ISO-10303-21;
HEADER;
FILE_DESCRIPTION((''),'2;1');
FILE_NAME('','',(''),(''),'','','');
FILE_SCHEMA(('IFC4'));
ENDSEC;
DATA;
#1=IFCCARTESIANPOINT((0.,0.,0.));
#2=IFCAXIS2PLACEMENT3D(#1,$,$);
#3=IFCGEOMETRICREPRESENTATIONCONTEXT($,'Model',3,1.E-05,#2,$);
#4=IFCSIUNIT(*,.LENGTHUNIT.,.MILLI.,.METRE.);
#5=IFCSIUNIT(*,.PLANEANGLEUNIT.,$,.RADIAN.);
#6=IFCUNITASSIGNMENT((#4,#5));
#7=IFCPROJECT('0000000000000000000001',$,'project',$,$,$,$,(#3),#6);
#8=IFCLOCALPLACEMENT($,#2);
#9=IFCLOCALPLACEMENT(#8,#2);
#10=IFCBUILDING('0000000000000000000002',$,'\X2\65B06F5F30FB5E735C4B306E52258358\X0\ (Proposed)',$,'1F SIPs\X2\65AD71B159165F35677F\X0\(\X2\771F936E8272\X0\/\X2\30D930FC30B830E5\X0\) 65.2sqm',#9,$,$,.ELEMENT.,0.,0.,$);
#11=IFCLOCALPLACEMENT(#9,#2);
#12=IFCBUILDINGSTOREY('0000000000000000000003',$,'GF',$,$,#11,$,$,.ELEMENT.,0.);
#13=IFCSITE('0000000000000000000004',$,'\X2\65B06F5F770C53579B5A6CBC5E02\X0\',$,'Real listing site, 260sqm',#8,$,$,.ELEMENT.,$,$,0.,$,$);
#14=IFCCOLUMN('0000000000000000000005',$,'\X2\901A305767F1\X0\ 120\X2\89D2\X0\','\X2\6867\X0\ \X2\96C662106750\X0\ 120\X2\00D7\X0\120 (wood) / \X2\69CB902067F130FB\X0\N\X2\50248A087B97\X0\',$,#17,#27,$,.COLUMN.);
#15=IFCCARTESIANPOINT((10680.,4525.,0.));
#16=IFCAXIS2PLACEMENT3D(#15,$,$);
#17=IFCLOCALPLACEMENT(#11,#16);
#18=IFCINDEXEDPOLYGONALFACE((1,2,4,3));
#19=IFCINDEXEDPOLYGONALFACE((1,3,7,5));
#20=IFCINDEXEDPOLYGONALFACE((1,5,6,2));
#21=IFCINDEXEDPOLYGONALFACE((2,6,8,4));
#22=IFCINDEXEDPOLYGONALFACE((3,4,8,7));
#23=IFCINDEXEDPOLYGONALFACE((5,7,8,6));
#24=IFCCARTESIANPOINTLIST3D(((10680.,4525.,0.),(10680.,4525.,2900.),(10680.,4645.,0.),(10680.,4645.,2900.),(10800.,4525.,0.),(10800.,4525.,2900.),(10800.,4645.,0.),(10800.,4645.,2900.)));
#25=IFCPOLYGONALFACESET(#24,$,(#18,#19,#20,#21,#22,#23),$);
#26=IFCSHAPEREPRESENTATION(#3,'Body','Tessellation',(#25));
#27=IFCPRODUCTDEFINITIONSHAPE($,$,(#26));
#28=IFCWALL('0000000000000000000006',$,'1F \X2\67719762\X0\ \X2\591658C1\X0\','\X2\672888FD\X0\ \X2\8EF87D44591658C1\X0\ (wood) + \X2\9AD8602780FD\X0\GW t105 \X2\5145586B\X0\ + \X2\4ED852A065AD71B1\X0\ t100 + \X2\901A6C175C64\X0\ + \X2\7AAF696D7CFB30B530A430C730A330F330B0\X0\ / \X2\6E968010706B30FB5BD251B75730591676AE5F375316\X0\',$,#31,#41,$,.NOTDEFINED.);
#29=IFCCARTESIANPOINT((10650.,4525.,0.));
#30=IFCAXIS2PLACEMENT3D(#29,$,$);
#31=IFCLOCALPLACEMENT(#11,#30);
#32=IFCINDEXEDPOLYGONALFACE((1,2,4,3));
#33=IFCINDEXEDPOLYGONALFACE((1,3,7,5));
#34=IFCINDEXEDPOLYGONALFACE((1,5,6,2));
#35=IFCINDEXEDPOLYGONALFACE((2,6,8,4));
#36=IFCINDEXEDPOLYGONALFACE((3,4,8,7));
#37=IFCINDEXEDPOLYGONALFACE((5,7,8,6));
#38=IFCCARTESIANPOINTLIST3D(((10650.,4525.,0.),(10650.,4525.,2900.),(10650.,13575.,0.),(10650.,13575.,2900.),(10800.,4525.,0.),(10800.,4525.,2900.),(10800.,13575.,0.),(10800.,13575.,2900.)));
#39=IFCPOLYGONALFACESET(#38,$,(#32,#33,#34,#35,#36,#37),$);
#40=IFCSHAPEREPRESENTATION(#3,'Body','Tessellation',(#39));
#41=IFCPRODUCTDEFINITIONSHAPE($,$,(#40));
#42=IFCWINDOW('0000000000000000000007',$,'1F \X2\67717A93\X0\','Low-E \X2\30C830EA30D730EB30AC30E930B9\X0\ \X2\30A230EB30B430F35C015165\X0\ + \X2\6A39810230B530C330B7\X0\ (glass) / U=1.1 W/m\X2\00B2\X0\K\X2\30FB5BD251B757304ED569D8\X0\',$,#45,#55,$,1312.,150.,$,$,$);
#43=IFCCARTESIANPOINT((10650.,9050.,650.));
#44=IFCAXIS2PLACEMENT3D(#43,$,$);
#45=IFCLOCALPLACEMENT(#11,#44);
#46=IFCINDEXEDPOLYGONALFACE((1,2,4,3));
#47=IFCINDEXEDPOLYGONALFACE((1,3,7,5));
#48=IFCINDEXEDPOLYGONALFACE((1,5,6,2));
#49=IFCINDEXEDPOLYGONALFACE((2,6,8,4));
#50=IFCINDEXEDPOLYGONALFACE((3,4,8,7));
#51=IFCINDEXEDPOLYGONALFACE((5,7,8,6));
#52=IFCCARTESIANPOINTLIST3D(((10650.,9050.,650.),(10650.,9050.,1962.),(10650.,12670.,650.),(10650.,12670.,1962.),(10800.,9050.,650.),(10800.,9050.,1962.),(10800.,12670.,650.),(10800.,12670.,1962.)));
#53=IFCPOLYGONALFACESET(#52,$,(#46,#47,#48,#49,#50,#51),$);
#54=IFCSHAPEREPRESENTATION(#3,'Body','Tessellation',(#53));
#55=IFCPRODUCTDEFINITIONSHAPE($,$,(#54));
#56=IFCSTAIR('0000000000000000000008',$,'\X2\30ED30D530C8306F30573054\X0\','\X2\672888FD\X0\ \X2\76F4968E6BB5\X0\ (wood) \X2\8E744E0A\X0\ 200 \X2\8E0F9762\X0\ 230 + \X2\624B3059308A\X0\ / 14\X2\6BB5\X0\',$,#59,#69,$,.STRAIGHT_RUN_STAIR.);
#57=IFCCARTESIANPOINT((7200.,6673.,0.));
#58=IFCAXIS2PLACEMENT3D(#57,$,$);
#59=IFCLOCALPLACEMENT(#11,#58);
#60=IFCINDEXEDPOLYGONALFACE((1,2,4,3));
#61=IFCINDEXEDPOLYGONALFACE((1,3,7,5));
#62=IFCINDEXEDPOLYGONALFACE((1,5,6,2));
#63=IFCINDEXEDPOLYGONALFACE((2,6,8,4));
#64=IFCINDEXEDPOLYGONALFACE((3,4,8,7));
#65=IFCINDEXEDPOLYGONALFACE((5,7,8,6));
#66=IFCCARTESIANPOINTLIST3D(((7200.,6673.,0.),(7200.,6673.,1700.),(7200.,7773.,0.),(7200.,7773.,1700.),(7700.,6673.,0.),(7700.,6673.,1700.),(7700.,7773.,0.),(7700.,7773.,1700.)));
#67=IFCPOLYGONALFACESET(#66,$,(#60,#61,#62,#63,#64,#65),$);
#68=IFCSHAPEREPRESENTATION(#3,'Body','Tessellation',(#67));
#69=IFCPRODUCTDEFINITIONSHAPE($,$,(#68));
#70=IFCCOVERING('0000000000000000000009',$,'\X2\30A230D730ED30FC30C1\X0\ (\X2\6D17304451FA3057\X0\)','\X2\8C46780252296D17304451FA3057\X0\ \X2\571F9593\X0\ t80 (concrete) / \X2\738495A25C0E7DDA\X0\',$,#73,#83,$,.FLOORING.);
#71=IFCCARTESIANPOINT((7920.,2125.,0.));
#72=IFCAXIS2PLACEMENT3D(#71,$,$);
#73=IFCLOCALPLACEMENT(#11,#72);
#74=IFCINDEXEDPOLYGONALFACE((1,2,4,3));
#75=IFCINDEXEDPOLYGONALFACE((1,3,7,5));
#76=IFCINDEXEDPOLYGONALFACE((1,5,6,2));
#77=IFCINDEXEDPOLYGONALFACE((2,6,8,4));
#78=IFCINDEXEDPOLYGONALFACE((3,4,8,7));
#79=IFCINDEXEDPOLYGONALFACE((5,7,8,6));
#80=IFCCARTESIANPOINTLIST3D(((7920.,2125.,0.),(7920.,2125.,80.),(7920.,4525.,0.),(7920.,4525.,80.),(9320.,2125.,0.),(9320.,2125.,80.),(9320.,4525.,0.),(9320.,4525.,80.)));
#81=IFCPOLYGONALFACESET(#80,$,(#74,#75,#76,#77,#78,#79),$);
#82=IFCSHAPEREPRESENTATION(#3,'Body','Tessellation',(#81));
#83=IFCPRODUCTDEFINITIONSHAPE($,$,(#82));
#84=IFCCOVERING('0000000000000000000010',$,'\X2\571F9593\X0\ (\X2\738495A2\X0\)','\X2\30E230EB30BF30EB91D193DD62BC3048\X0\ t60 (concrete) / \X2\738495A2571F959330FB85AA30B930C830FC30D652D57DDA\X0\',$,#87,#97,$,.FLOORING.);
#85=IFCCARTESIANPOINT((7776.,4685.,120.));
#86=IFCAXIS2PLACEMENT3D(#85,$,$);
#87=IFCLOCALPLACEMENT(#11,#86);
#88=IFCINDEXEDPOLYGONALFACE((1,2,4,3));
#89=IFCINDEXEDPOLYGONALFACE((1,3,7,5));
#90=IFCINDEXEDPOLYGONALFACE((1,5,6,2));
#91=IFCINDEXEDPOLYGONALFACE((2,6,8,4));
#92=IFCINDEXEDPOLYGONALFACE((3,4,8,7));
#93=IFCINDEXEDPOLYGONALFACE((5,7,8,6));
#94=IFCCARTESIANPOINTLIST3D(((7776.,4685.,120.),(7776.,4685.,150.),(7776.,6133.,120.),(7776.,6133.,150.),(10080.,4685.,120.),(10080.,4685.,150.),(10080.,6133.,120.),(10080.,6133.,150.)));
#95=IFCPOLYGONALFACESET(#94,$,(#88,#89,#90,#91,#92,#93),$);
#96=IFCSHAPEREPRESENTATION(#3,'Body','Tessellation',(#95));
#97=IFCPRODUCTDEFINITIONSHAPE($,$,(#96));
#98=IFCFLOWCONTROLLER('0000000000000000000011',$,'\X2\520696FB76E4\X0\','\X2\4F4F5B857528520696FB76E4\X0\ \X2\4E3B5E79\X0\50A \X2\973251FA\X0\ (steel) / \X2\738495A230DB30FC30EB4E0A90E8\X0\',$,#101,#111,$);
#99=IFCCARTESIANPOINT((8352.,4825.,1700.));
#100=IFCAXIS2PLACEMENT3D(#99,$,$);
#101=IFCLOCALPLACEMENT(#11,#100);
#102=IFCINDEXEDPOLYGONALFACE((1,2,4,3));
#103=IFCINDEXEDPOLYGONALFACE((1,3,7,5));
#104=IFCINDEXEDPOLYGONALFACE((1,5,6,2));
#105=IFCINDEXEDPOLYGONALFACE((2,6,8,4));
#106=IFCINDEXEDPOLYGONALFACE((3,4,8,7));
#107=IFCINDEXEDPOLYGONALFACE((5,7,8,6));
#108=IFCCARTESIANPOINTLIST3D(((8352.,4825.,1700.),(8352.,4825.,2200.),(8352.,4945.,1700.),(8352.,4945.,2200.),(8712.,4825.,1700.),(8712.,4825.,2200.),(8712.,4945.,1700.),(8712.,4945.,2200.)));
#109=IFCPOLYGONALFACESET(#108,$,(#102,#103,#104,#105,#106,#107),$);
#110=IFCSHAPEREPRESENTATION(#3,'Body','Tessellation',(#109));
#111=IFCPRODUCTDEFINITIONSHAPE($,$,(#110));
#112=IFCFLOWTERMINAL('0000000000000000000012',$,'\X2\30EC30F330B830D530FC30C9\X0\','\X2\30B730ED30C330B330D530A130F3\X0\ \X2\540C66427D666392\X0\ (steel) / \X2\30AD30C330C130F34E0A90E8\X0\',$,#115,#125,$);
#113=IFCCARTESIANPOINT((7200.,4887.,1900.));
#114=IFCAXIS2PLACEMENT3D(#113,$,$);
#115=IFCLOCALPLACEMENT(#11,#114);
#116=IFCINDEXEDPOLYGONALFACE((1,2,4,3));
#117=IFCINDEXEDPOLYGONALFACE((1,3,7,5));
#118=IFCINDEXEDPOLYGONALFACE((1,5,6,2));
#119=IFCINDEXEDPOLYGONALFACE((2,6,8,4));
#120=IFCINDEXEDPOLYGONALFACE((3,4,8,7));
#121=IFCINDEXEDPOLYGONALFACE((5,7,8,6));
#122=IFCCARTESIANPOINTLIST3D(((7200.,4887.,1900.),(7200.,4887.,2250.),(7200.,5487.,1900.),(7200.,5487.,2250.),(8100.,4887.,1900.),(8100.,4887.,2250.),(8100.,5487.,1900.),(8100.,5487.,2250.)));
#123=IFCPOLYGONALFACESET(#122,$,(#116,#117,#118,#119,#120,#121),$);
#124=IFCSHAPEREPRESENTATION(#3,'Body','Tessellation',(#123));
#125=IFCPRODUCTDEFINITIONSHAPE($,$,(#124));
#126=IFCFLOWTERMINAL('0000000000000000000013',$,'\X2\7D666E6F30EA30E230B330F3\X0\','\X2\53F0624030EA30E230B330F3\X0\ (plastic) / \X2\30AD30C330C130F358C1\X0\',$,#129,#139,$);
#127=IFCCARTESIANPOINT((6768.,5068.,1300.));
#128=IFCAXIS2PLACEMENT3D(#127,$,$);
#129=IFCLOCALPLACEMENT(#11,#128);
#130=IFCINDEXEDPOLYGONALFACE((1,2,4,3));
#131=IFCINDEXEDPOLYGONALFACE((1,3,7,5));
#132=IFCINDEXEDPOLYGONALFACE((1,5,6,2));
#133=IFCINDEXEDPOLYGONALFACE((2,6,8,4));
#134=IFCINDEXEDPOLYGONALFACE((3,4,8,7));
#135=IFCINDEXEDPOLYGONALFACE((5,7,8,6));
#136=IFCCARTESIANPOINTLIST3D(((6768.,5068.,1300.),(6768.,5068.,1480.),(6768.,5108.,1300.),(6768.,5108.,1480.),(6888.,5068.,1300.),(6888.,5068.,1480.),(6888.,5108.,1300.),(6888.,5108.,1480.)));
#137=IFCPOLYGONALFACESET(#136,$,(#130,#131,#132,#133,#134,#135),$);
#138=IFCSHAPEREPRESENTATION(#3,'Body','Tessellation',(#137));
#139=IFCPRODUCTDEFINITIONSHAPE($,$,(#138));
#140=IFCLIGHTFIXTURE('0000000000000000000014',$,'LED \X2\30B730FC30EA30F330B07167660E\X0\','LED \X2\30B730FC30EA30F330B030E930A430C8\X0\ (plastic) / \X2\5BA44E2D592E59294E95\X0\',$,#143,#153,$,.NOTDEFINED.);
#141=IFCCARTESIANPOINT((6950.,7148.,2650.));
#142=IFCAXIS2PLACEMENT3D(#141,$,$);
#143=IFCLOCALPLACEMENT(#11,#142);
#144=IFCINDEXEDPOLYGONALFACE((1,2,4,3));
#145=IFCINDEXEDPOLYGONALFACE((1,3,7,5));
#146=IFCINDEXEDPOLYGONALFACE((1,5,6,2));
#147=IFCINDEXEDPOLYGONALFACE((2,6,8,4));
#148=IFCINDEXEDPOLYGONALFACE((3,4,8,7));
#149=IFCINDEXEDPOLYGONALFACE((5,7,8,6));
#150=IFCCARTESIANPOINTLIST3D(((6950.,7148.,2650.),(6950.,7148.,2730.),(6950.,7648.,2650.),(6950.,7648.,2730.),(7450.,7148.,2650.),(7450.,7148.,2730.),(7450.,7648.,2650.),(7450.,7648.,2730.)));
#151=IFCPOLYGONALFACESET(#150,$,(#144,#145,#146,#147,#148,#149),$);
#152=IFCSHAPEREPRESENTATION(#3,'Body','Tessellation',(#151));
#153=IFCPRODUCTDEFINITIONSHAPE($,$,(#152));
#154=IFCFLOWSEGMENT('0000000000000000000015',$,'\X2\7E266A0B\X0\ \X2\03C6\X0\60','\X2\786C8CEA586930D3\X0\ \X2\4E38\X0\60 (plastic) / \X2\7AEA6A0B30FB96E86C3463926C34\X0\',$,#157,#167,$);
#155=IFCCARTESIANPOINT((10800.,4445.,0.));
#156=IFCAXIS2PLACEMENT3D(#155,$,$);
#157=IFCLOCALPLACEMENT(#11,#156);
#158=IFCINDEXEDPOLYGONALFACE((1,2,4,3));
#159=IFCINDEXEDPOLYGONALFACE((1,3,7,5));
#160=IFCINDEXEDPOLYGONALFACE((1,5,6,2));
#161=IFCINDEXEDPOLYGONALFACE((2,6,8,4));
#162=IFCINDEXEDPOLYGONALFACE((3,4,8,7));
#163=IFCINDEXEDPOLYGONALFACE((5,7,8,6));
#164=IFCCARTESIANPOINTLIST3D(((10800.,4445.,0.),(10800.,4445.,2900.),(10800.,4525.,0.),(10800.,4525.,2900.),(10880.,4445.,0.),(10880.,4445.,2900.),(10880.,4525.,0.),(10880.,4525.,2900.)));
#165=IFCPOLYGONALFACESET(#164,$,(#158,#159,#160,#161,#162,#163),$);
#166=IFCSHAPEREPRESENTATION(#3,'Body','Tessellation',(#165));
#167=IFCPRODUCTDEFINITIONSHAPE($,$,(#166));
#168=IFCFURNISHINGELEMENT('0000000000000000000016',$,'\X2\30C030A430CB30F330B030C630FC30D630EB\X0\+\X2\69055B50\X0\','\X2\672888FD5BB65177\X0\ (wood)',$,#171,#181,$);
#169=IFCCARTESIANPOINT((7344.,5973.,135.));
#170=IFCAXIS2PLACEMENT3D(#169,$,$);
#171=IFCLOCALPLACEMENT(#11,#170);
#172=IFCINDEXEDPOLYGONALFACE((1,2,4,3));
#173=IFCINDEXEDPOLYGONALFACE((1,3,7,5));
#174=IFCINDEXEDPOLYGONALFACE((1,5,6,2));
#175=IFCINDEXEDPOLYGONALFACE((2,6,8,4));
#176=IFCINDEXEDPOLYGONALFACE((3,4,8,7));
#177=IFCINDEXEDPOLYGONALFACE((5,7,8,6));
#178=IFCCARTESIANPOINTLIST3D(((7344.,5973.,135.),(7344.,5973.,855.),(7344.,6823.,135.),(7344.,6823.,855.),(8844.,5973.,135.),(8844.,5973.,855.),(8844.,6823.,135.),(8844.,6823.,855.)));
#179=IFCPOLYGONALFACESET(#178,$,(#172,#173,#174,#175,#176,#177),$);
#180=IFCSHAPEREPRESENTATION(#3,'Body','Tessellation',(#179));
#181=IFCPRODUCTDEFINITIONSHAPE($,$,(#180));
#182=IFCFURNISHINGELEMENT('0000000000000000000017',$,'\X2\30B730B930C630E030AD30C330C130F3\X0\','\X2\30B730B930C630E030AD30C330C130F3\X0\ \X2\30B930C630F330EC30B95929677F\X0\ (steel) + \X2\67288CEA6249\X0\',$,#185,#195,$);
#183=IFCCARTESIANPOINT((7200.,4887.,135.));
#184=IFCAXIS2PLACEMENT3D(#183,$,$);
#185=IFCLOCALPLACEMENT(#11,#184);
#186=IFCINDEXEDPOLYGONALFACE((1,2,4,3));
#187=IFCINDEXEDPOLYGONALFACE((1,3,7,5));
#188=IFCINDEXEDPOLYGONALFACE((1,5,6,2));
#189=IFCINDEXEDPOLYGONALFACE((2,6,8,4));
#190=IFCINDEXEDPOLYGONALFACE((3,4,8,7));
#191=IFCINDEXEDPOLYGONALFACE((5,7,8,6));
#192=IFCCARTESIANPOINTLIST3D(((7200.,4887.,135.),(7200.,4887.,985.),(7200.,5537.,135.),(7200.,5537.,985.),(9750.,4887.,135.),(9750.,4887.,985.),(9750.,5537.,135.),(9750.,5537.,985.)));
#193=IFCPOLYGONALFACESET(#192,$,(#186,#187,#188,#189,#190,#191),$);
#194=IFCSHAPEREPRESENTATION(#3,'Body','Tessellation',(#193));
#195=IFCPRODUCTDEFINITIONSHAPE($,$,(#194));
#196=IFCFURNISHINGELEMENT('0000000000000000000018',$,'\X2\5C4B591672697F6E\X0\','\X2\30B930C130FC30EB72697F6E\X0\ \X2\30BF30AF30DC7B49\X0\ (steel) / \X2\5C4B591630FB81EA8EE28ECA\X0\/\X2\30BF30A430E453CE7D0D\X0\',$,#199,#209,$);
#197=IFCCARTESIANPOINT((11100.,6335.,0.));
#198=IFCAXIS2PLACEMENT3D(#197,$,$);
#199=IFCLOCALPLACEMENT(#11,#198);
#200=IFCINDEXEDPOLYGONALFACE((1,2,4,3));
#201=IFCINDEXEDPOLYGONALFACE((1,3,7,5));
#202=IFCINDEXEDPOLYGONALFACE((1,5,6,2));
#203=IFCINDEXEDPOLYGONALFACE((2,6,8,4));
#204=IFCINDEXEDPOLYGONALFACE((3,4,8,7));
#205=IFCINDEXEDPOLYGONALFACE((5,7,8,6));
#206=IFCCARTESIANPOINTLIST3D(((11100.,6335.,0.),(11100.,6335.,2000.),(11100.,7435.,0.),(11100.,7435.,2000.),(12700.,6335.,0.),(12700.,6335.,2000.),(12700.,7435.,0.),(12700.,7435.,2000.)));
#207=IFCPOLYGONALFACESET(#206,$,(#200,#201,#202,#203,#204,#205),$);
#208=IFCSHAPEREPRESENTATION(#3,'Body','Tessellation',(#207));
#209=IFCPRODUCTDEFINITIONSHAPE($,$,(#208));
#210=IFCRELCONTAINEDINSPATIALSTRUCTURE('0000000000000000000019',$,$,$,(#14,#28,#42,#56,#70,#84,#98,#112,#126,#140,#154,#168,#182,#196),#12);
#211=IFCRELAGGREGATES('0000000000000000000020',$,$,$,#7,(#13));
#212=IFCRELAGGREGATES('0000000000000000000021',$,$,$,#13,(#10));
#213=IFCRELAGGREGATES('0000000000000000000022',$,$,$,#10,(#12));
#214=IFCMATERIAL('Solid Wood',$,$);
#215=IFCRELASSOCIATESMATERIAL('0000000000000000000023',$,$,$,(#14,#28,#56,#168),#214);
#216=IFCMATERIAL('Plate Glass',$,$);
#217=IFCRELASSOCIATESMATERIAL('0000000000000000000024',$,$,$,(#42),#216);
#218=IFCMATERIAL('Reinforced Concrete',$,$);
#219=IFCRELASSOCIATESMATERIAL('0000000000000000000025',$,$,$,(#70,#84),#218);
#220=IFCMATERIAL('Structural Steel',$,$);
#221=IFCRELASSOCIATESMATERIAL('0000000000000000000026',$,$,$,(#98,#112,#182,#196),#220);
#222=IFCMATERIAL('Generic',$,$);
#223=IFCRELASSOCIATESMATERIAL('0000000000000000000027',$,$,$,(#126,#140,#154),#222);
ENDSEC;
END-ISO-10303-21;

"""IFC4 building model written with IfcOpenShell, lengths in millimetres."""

from ifc_helpers import new_model, si_unit, frame, frame_2d, origin, place, context, project, spatial, rectangle, extrude, material, element, fill, save


model = new_model("IFC4")

# Units and contexts
model_context = context("Model", 3, precision=1e-05, world=origin())
ifc_project = project(units=[si_unit("LENGTHUNIT", "METRE", prefix="MILLI"), si_unit("PLANEANGLEUNIT", "RADIAN")], contexts=[model_context])

# Site, building, storey
site_placement = place(None, origin())
site = spatial("IfcSite", under=ifc_project, at=site_placement, Name="新潟県南魚沼市", ObjectType="Real listing site, 260sqm", CompositionType="ELEMENT", RefElevation=0.0)
building_placement = place(site_placement, origin())
building = spatial("IfcBuilding", under=site, at=building_placement, Name="新潟・平屋の別荘 (Proposed)", ObjectType="1F SIPs断熱外張板(真鍮色/ベージュ) 65.2sqm", CompositionType="ELEMENT", ElevationOfRefHeight=0.0, ElevationOfTerrain=0.0)
storey_placement = place(building_placement, origin())
storey = spatial("IfcBuildingStorey", under=building, at=storey_placement, Name="GF", CompositionType="ELEMENT", Elevation=0.0)

# Column
ifc_material_1 = material(Name="Solid Wood")
column_1_placement = place(storey_placement, frame((10680.0, 4525.0, 0.0)))
element("IfcColumn", 1, at=column_1_placement, inside=storey, material=ifc_material_1, Name="通し柱 120角", Description="桧 集成材 120×120 (wood) / 構造柱・N値計算", PredefinedType="COLUMN", context=model_context, shape_type="SweptSolid", body=[
    extrude(rectangle(XDim=120.0, YDim=120.0, at=frame_2d((60.0, 60.0))), frame((10680.0, 4525.0, 0.0)), (0.0, 0.0, 1.0), 2900.0),
])

# Wall, opening, window
wall_1_placement = place(storey_placement, frame((10650.0, 4525.0, 0.0)))
wall_1 = element("IfcWall", 2, at=wall_1_placement, inside=storey, material=ifc_material_1, Name="1F 東面 外壁", Description="木製 軸組外壁 (wood) + 高性能GW t105 充填 + 付加断熱 t100 + 通気層 + 窯業系サイディング / 準耐火・寒冷地外皮強化", PredefinedType="NOTDEFINED", context=model_context, shape_type="SweptSolid", body=[
    extrude(rectangle(XDim=150.0, YDim=9050.0, at=frame_2d((75.0, 4525.0))), frame((10650.0, 4525.0, 0.0)), (0.0, 0.0, 1.0), 2900.0),
])
opening_placement = place(storey_placement, frame((10650.0, 9050.0, 650.0)))
opening = element("IfcOpeningElement", 3, at=opening_placement, cuts=wall_1, PredefinedType="NOTDEFINED", context=model_context, shape_type="SweptSolid", body=[
    extrude(rectangle(XDim=150.0, YDim=3620.0, at=frame_2d((75.0, 1810.0))), frame((10650.0, 9050.0, 650.0)), (0.0, 0.0, 1.0), 1312.0),
])
ifc_material_2 = material(Name="Plate Glass")
window_placement = place(storey_placement, frame((10650.0, 9050.0, 650.0)))
window = element("IfcWindow", 4, at=window_placement, inside=storey, material=ifc_material_2, Name="1F 東窓", Description="Low-E トリプルガラス アルゴン封入 + 樹脂サッシ (glass) / U=1.1 W/m²K・寒冷地仕様", OverallHeight=1312.0, OverallWidth=150.0, context=model_context, shape_type="SweptSolid", body=[
    extrude(rectangle(XDim=150.0, YDim=3620.0, at=frame_2d((75.0, 1810.0))), frame((10650.0, 9050.0, 650.0)), (0.0, 0.0, 1.0), 1312.0),
])
fill(opening, window)

# Stair
stair_placement = place(storey_placement, frame((7200.0, 6673.0, 0.0)))
element("IfcStair", 5, at=stair_placement, inside=storey, material=ifc_material_1, Name="ロフトはしご", Description="木製 直階段 (wood) 蹴上 200 踏面 230 + 手すり / 14段", PredefinedType="STRAIGHT_RUN_STAIR", context=model_context, shape_type="SweptSolid", body=[
    extrude(rectangle(XDim=500.0, YDim=1100.0, at=frame_2d((250.0, 550.0))), frame((7200.0, 6673.0, 0.0)), (0.0, 0.0, 1.0), 1700.0),
])

# Coverings
ifc_material_3 = material(Name="Reinforced Concrete")
covering_1_placement = place(storey_placement, frame((7920.0, 2125.0, 0.0)))
element("IfcCovering", 6, at=covering_1_placement, inside=storey, material=ifc_material_3, Name="アプローチ (洗い出し)", Description="豆砂利洗い出し 土間 t80 (concrete) / 玄関導線", PredefinedType="FLOORING", context=model_context, shape_type="SweptSolid", body=[
    extrude(rectangle(XDim=1400.0, YDim=2400.0, at=frame_2d((700.0, 1200.0))), frame((7920.0, 2125.0, 0.0)), (0.0, 0.0, 1.0), 80.0),
])
covering_2_placement = place(storey_placement, frame((7776.0, 4685.0, 120.0)))
element("IfcCovering", 7, at=covering_2_placement, inside=storey, material=ifc_material_3, Name="土間 (玄関)", Description="モルタル金鏝押え t60 (concrete) / 玄関土間・薪ストーブ動線", PredefinedType="FLOORING", context=model_context, shape_type="SweptSolid", body=[
    extrude(rectangle(XDim=2304.0, YDim=1448.0, at=frame_2d((1152.0, 724.0))), frame((7776.0, 4685.0, 120.0)), (0.0, 0.0, 1.0), 30.0),
])

# Flow controller
ifc_material_4 = material(Name="Structural Steel")
flow_controller_placement = place(storey_placement, frame((8352.0, 4825.0, 1700.0)))
element("IfcFlowController", 8, at=flow_controller_placement, inside=storey, material=ifc_material_4, Name="分電盤", Description="住宅用分電盤 主幹50A 露出 (steel) / 玄関ホール上部", context=model_context, shape_type="SweptSolid", body=[
    extrude(rectangle(XDim=360.0, YDim=120.0, at=frame_2d((180.0, 60.0))), frame((8352.0, 4825.0, 1700.0)), (0.0, 0.0, 1.0), 500.0),
])

# Flow terminals
flow_terminal_1_placement = place(storey_placement, frame((7200.0, 4887.0, 1900.0)))
element("IfcFlowTerminal", 9, at=flow_terminal_1_placement, inside=storey, material=ifc_material_4, Name="レンジフード", Description="シロッコファン 同時給排 (steel) / キッチン上部", context=model_context, shape_type="SweptSolid", body=[
    extrude(rectangle(XDim=900.0, YDim=600.0, at=frame_2d((450.0, 300.0))), frame((7200.0, 4887.0, 1900.0)), (0.0, 0.0, 1.0), 350.0),
])
ifc_material_5 = material(Name="Generic")
flow_terminal_2_placement = place(storey_placement, frame((6768.0, 5068.0, 1300.0)))
element("IfcFlowTerminal", 10, at=flow_terminal_2_placement, inside=storey, material=ifc_material_5, Name="給湯リモコン", Description="台所リモコン (plastic) / キッチン壁", context=model_context, shape_type="SweptSolid", body=[
    extrude(rectangle(XDim=120.0, YDim=40.0, at=frame_2d((60.0, 20.0))), frame((6768.0, 5068.0, 1300.0)), (0.0, 0.0, 1.0), 180.0),
])

# Light fixture
light_fixture_placement = place(storey_placement, frame((6950.0, 7148.0, 2650.0)))
element("IfcLightFixture", 11, at=light_fixture_placement, inside=storey, material=ifc_material_5, Name="LED シーリング照明", Description="LED シーリングライト (plastic) / 室中央天井", PredefinedType="NOTDEFINED", context=model_context, shape_type="SweptSolid", body=[
    extrude(rectangle(XDim=500.0, YDim=500.0, at=frame_2d((250.0, 250.0))), frame((6950.0, 7148.0, 2650.0)), (0.0, 0.0, 1.0), 80.0),
])

# Flow segment
flow_segment_placement = place(storey_placement, frame((10800.0, 4445.0, 0.0)))
element("IfcFlowSegment", 12, at=flow_segment_placement, inside=storey, material=ifc_material_5, Name="縦樋 φ60", Description="硬質塩ビ 丸60 (plastic) / 竪樋・雨水排水", context=model_context, shape_type="SweptSolid", body=[
    extrude(rectangle(XDim=80.0, YDim=80.0, at=frame_2d((40.0, 40.0))), frame((10800.0, 4445.0, 0.0)), (0.0, 0.0, 1.0), 2900.0),
])

# Furnishing elements
furnishing_1_placement = place(storey_placement, frame((7344.0, 5973.0, 135.0)))
element("IfcFurnishingElement", 13, at=furnishing_1_placement, inside=storey, material=ifc_material_1, Name="ダイニングテーブル+椅子", Description="木製家具 (wood)", context=model_context, shape_type="SweptSolid", body=[
    extrude(rectangle(XDim=1500.0, YDim=850.0, at=frame_2d((750.0, 425.0))), frame((7344.0, 5973.0, 135.0)), (0.0, 0.0, 1.0), 720.0),
])
furnishing_2_placement = place(storey_placement, frame((7200.0, 4887.0, 135.0)))
element("IfcFurnishingElement", 14, at=furnishing_2_placement, inside=storey, material=ifc_material_4, Name="システムキッチン", Description="システムキッチン ステンレス天板 (steel) + 木質扉", context=model_context, shape_type="SweptSolid", body=[
    extrude(rectangle(XDim=2550.0, YDim=650.0, at=frame_2d((1275.0, 325.0))), frame((7200.0, 4887.0, 135.0)), (0.0, 0.0, 1.0), 850.0),
])
furnishing_3_placement = place(storey_placement, frame((11100.0, 6335.0, 0.0)))
element("IfcFurnishingElement", 15, at=furnishing_3_placement, inside=storey, material=ifc_material_4, Name="屋外物置", Description="スチール物置 タクボ等 (steel) / 屋外・自転車/タイヤ収納", context=model_context, shape_type="SweptSolid", body=[
    extrude(rectangle(XDim=1600.0, YDim=1100.0, at=frame_2d((800.0, 550.0))), frame((11100.0, 6335.0, 0.0)), (0.0, 0.0, 1.0), 2000.0),
])

save(model, "model.ifc")
